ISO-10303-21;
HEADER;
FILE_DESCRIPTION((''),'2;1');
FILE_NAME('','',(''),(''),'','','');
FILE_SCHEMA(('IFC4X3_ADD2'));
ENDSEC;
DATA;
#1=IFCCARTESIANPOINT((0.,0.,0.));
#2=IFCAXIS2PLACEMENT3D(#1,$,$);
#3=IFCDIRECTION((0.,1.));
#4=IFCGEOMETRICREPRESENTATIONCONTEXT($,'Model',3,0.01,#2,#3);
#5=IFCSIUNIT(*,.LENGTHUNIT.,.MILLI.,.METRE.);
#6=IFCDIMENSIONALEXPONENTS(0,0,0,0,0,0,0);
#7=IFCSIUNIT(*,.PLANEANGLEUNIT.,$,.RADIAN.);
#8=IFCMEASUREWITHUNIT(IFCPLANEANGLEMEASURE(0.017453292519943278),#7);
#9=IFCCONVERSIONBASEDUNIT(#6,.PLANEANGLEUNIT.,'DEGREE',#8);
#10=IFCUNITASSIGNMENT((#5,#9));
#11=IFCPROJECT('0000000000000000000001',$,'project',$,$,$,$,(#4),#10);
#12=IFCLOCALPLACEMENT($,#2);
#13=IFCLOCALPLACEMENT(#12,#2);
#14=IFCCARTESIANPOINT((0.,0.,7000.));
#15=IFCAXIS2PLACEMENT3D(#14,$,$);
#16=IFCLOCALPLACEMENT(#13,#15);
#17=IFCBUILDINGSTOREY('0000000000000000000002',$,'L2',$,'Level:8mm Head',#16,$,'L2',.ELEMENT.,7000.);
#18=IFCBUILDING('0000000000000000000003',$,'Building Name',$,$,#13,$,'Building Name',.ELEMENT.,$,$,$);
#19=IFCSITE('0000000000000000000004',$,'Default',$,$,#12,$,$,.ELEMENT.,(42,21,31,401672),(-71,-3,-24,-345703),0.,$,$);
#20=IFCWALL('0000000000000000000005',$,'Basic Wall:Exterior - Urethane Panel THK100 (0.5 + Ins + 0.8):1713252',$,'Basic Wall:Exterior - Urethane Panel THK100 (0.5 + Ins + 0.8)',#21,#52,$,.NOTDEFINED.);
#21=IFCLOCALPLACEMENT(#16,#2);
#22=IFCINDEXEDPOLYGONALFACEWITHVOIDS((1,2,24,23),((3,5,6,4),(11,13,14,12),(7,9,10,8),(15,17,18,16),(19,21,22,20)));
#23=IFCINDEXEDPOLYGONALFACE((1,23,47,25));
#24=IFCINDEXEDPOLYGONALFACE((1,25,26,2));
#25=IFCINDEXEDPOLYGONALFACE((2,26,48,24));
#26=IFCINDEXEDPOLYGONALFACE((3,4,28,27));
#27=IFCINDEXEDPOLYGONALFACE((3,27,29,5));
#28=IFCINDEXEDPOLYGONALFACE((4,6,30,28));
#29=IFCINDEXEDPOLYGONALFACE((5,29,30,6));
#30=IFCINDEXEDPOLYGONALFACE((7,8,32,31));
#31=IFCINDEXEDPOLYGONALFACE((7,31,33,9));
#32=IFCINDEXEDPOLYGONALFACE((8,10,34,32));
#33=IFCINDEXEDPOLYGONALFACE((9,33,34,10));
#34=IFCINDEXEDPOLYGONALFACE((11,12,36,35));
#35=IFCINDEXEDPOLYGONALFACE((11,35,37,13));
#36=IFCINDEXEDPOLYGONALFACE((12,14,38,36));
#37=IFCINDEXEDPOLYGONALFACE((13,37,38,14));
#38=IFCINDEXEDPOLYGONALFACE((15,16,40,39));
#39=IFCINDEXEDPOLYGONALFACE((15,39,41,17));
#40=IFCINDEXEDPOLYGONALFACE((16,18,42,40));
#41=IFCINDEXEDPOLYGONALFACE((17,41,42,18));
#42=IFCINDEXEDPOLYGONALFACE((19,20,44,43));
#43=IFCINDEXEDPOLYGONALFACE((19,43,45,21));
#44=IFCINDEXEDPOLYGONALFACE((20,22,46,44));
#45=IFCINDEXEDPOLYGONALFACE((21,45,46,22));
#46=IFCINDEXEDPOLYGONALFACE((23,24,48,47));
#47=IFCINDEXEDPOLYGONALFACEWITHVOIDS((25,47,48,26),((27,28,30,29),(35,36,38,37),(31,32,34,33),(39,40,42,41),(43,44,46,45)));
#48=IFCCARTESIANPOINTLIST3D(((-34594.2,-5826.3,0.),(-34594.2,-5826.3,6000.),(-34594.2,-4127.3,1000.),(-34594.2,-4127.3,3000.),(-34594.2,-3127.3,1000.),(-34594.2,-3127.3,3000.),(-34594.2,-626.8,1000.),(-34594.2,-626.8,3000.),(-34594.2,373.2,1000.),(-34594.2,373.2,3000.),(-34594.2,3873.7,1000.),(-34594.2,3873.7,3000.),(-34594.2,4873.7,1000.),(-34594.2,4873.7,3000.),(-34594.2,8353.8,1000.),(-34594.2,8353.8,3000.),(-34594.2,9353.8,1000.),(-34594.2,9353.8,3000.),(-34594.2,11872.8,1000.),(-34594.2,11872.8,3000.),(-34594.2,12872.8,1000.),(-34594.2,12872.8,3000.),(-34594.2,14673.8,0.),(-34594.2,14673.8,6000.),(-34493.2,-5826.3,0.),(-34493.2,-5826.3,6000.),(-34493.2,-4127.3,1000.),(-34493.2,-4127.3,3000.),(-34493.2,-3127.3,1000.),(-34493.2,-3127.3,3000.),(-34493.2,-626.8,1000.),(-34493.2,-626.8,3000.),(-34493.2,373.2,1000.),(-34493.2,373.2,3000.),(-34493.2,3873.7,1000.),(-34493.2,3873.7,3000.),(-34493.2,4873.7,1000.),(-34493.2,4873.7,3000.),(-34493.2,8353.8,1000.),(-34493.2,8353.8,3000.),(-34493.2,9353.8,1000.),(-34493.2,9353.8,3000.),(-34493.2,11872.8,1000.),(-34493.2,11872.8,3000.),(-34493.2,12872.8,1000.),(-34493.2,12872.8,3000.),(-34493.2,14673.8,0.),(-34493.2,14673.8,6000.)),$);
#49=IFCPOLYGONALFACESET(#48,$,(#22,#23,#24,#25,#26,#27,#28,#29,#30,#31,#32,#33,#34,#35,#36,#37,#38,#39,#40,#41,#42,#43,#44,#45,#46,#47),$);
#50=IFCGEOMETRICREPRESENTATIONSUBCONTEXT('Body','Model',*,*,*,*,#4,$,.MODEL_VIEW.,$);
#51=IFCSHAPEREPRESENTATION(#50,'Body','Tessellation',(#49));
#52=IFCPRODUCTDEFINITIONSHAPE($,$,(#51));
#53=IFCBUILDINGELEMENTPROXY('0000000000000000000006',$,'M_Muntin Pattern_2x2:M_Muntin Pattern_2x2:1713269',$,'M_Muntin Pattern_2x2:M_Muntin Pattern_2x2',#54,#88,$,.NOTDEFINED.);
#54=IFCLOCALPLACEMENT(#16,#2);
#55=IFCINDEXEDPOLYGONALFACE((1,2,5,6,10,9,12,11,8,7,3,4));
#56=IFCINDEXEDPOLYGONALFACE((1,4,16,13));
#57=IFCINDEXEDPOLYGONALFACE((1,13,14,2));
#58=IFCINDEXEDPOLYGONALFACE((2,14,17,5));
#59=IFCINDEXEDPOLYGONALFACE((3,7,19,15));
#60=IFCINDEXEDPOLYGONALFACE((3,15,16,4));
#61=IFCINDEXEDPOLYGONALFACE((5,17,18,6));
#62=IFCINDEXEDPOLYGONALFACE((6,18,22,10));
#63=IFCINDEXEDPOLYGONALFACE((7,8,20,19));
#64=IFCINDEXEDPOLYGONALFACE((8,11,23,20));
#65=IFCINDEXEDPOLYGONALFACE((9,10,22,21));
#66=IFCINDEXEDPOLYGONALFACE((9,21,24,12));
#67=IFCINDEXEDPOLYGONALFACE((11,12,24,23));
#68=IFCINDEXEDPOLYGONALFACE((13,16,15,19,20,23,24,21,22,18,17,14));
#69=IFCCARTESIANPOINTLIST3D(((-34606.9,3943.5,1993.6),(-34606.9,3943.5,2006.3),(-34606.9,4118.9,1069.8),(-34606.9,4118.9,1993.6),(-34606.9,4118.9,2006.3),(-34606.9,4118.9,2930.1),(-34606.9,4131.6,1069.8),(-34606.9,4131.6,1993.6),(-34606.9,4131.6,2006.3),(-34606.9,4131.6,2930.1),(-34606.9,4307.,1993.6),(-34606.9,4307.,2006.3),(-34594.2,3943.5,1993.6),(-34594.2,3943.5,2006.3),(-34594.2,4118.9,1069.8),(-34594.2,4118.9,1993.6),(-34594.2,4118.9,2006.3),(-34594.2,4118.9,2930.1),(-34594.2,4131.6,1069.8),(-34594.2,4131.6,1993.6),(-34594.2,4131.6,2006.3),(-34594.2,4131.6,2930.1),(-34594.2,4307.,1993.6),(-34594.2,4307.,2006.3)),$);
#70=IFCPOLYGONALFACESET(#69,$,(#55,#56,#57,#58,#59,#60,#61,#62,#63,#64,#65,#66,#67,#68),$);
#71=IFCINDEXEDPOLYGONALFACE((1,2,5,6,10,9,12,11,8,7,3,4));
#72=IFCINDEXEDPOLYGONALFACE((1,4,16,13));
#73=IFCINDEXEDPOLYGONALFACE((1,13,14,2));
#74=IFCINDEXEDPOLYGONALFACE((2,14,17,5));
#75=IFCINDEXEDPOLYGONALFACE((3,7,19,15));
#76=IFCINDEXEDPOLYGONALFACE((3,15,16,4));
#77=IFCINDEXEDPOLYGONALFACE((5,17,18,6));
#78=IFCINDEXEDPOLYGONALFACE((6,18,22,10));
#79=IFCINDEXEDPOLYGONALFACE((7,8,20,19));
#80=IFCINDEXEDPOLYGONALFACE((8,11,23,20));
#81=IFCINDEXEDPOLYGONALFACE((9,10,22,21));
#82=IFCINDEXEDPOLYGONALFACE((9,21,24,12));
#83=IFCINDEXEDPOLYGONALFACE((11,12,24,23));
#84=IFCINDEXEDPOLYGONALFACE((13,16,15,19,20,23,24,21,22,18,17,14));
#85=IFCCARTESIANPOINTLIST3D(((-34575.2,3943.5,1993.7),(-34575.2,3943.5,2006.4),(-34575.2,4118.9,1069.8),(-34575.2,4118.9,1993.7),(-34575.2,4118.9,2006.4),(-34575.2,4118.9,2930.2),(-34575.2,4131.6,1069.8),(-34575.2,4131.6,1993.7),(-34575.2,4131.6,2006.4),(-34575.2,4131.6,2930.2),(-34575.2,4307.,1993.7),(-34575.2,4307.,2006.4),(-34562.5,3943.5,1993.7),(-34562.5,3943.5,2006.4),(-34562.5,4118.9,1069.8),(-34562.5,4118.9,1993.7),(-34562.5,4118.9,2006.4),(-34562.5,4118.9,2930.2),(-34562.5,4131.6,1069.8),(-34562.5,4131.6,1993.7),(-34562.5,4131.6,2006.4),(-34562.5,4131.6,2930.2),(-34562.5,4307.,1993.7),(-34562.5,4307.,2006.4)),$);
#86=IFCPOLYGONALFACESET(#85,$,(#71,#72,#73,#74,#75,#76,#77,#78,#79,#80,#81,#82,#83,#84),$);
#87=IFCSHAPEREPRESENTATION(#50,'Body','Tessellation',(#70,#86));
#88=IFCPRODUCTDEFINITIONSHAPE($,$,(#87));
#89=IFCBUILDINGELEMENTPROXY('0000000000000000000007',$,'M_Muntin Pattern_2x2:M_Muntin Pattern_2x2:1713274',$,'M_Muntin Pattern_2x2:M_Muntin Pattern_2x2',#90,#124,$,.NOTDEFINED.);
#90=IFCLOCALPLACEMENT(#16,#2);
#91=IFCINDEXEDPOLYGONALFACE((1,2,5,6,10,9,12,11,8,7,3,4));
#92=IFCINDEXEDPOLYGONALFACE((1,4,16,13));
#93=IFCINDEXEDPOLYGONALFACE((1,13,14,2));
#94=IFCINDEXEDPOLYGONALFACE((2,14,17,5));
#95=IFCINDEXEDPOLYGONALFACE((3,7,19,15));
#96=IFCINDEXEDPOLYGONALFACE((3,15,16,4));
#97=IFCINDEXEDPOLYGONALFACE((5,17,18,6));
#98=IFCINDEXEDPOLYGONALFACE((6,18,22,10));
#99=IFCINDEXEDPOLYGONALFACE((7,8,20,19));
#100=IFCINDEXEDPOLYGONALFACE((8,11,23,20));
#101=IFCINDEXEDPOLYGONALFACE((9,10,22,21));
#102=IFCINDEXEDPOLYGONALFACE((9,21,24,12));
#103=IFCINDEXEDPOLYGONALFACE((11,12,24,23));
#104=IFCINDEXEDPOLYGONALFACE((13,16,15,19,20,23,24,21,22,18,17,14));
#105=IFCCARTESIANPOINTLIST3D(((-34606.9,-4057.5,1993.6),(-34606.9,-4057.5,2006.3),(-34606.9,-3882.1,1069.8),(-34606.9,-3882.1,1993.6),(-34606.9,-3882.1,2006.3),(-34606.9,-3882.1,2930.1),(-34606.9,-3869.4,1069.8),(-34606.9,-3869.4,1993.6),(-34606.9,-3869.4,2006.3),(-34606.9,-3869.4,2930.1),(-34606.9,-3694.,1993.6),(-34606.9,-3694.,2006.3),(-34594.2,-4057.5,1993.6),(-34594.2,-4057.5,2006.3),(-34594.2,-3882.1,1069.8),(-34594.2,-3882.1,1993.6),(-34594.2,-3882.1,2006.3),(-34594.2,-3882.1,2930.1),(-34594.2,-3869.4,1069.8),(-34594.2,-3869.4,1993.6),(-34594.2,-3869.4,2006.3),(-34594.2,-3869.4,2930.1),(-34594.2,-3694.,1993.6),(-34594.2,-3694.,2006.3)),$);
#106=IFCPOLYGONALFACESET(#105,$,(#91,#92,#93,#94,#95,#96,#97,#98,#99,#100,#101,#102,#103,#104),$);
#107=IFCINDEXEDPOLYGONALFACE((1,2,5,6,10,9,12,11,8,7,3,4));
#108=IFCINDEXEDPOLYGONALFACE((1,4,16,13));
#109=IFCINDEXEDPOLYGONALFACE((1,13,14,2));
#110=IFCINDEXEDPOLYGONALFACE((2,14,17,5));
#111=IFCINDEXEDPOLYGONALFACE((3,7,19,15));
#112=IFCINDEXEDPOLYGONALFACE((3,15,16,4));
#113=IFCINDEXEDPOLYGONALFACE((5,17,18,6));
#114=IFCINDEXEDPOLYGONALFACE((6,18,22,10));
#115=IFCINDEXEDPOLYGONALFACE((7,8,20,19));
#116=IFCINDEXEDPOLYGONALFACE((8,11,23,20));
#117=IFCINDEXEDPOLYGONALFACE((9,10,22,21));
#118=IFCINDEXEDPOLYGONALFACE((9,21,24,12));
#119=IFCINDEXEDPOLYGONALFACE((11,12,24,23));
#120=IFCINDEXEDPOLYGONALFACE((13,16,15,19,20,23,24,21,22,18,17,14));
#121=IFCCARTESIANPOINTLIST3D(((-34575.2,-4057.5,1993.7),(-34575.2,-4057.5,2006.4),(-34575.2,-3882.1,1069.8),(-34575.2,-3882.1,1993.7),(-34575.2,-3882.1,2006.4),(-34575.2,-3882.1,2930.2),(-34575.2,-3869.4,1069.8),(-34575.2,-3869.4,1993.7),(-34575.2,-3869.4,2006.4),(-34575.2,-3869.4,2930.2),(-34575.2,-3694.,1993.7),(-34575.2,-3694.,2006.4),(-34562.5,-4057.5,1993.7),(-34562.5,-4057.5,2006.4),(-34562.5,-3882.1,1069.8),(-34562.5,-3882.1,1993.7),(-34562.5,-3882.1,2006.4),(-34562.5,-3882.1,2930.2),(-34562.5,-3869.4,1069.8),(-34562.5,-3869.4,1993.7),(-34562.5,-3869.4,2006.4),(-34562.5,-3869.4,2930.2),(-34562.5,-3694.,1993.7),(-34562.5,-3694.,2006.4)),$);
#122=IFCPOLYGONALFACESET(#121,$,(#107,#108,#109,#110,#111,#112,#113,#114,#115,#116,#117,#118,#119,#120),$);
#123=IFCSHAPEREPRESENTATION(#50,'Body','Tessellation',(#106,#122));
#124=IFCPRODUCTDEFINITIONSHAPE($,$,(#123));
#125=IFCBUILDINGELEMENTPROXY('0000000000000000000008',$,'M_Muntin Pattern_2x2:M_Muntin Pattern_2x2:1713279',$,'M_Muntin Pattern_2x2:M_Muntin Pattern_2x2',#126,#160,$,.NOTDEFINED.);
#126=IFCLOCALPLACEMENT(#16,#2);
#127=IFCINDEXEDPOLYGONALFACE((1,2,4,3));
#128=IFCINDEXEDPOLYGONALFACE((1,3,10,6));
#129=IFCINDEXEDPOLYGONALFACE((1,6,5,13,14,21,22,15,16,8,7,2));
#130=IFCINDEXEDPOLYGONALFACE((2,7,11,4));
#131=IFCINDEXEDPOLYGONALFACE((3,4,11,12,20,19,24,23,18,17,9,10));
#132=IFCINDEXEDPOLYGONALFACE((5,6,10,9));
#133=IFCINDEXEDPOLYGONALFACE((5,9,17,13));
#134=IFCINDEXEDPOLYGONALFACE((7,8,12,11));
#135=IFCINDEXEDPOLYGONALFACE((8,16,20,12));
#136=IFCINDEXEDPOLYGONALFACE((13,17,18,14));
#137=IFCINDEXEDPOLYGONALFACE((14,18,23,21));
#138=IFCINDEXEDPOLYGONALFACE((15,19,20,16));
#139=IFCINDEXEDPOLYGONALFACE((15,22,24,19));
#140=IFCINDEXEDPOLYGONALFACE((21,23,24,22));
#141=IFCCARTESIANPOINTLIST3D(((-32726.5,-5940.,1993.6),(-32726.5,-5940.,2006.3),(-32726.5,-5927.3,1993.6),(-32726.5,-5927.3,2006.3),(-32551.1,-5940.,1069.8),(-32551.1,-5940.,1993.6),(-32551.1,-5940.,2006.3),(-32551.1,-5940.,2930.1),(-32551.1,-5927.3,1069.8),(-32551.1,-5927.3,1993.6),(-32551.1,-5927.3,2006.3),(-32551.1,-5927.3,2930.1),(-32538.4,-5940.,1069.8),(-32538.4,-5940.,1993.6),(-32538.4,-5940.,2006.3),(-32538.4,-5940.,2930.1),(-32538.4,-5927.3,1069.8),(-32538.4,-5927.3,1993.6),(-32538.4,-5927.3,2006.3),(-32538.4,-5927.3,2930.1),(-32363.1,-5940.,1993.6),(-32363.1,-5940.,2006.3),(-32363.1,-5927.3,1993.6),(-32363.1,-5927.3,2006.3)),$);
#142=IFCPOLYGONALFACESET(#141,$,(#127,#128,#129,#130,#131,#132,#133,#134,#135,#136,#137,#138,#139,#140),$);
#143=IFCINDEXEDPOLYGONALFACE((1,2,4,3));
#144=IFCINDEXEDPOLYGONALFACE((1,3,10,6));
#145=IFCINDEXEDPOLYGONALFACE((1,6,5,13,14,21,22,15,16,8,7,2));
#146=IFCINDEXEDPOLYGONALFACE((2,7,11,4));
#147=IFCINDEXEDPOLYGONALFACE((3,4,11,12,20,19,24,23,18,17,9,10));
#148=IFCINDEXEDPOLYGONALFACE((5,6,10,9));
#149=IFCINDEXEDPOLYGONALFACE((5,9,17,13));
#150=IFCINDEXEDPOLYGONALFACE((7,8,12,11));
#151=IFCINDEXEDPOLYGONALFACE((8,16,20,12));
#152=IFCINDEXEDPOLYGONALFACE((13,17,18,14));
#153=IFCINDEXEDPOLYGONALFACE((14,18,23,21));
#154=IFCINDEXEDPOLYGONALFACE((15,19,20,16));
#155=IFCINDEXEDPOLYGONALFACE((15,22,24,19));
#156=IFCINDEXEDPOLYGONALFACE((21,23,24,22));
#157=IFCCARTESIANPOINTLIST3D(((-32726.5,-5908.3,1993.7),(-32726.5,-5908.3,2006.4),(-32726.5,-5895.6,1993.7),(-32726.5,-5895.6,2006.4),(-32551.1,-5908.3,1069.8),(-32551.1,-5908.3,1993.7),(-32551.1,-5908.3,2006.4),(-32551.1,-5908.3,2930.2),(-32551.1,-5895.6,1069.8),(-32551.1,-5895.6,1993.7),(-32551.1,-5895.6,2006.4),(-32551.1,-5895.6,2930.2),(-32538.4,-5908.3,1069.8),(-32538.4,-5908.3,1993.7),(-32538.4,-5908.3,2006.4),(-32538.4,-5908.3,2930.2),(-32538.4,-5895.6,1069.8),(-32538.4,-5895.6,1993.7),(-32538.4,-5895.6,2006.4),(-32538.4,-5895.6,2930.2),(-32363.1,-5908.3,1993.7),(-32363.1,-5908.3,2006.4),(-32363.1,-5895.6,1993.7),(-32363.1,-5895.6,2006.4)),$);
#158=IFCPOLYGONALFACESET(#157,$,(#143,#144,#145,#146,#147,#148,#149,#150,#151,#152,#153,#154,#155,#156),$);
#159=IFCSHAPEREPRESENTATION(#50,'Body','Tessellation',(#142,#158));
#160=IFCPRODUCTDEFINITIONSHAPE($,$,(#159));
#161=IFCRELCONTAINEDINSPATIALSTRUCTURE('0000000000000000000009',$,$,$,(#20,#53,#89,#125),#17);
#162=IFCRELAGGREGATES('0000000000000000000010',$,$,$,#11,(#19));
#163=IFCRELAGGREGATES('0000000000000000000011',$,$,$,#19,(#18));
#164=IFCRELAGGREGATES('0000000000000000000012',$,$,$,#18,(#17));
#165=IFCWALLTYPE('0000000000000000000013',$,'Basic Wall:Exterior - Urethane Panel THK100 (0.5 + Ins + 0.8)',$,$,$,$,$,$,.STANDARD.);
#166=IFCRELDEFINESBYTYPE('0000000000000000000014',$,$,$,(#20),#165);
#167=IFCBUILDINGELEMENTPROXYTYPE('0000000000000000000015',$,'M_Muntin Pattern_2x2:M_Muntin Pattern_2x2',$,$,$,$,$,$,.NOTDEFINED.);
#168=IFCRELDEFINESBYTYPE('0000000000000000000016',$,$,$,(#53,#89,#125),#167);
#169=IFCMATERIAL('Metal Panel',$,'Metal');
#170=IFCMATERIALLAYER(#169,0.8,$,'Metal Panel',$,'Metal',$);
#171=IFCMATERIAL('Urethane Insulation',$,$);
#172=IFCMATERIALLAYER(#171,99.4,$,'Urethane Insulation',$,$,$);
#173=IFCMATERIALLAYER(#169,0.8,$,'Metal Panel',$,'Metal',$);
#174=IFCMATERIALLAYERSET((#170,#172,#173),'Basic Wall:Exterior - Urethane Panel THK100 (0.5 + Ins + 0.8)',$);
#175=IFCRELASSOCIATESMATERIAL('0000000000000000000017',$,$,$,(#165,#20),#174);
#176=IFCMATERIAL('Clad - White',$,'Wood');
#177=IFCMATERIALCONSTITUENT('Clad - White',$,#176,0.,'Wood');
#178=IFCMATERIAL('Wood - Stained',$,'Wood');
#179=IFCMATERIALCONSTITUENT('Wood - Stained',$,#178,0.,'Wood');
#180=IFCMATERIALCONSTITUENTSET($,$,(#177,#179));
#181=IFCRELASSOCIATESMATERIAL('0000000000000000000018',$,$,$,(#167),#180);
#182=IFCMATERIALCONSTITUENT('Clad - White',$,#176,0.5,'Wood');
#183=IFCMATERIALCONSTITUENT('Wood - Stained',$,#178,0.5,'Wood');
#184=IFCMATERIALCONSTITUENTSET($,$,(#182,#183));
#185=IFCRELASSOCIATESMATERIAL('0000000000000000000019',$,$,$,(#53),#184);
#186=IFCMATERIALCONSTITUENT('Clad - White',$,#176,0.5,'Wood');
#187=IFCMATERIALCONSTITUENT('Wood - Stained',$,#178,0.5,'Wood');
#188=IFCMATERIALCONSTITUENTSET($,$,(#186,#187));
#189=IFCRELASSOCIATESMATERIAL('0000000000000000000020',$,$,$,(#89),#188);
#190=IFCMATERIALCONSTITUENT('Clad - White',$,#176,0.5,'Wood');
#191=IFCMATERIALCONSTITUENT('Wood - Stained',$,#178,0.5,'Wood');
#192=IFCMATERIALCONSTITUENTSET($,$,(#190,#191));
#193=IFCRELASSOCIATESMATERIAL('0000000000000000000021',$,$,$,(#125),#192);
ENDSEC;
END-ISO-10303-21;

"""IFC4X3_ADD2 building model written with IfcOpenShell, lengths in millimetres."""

from ifc_helpers import new_model, entity, si_unit, converted_unit, direction, frame, frame_2d, origin, place, context, subcontext, project, spatial, polyline, rectangle, outline, extrude, source, transform, mapped, material, layer, layer_set, constituent, constituent_set, type_object, type_shapes, element, save


model = new_model("IFC4X3_ADD2")

# Units and contexts
model_context = context("Model", 3, precision=0.01, world=origin(), true_north=direction((0.0, 1.0)))
body_context = subcontext(model_context, "Body", "Model", "MODEL_VIEW")
ifc_project = project(units=[si_unit("LENGTHUNIT", "METRE", prefix="MILLI"), converted_unit("PLANEANGLEUNIT", "DEGREE", entity("IfcPlaneAngleMeasure", 0.017453292519943278), si_unit("PLANEANGLEUNIT", "RADIAN"), dimensions=[0, 0, 0, 0, 0, 0, 0])], contexts=[model_context])

# Site, building, storey
site_placement = place(None, origin())
site = spatial("IfcSite", under=ifc_project, at=site_placement, Name="Default", CompositionType="ELEMENT", RefLatitude=(42, 21, 31, 401672), RefLongitude=(-71, -3, -24, -345703), RefElevation=0.0)
building_placement = place(site_placement, origin())
building = spatial("IfcBuilding", under=site, at=building_placement, Name="Building Name", LongName="Building Name", CompositionType="ELEMENT")
storey_placement = place(building_placement, frame((0.0, 0.0, 7000.0)))
storey = spatial("IfcBuildingStorey", under=building, at=storey_placement, Name="L2", ObjectType="Level:8mm Head", LongName="L2", CompositionType="ELEMENT", Elevation=7000.0)

# Wall, openings
ifc_material_1 = material(Name="Metal Panel", Category="Metal")
ifc_layer_1 = layer(ifc_material_1, 0.8, Name="Metal Panel", Category="Metal")
ifc_material_2 = material(Name="Urethane Insulation")
ifc_layer_2 = layer(ifc_material_2, 99.4, Name="Urethane Insulation")
ifc_layer_3 = layer(ifc_material_1, 0.8, Name="Metal Panel", Category="Metal")
ifc_layer_set = layer_set([ifc_layer_1, ifc_layer_2, ifc_layer_3], Name="Basic Wall:Exterior - Urethane Panel THK100 (0.5 + Ins + 0.8)")
wall_type = type_object("IfcWallType", Name="Basic Wall:Exterior - Urethane Panel THK100 (0.5 + Ins + 0.8)", PredefinedType="STANDARD", material=ifc_layer_set)
wall_placement = place(storey_placement, frame((-34543.7, -5826.3, 0.0), z_axis=(0.0, 0.0, 1.0), x_axis=(0.0, 1.0, 0.0)))
wall = element("IfcWall", 1, at=wall_placement, inside=storey, type_object=wall_type, material=ifc_layer_set, Name="Basic Wall:Exterior - Urethane Panel THK100 (0.5 + Ins + 0.8):1713252", ObjectType="Basic Wall:Exterior - Urethane Panel THK100 (0.5 + Ins + 0.8)", PredefinedType="NOTDEFINED", context=body_context, shape_type="SweptSolid", body=[
    extrude(rectangle(XDim=20500.1, YDim=101.0, at=frame_2d((10250.0, 0.0), x_axis=(-1.0, 0.0))), origin(), (0.0, 0.0, 1.0), 6000.0),
])
opening_1_placement = place(wall_placement, frame((17699.1, -50.5, 1000.0)))
element("IfcOpeningElement", 2, at=opening_1_placement, cuts=wall, PredefinedType="OPENING", context=body_context, shape_type="SweptSolid", body=[
    extrude(rectangle(XDim=2000.0, YDim=1000.0, at=frame_2d((1000.0, 500.0), x_axis=(-1.0, 0.0))), frame((0.0, 0.0, 0.0), z_axis=(0.0, 1.0, 0.0), x_axis=(0.0, 0.0, 1.0)), (0.0, 0.0, 1.0), 101.0),
])
opening_2_placement = place(wall_placement, frame((14180.1, -50.5, 1000.0)))
element("IfcOpeningElement", 3, at=opening_2_placement, cuts=wall, PredefinedType="OPENING", context=body_context, shape_type="SweptSolid", body=[
    extrude(rectangle(XDim=2000.0, YDim=1000.0, at=frame_2d((1000.0, 500.0), x_axis=(-1.0, 0.0))), frame((0.0, 0.0, 0.0), z_axis=(0.0, 1.0, 0.0), x_axis=(0.0, 0.0, 1.0)), (0.0, 0.0, 1.0), 101.0),
])
opening_3_placement = place(wall_placement, frame((9700.0, -50.5, 1000.0)))
element("IfcOpeningElement", 4, at=opening_3_placement, cuts=wall, PredefinedType="OPENING", context=body_context, shape_type="SweptSolid", body=[
    extrude(rectangle(XDim=2000.0, YDim=1000.0, at=frame_2d((1000.0, 500.0), x_axis=(-1.0, 0.0))), frame((0.0, 0.0, 0.0), z_axis=(0.0, 1.0, 0.0), x_axis=(0.0, 0.0, 1.0)), (0.0, 0.0, 1.0), 101.0),
])
opening_4_placement = place(wall_placement, frame((1699.0, -50.5, 1000.0)))
element("IfcOpeningElement", 5, at=opening_4_placement, cuts=wall, PredefinedType="OPENING", context=body_context, shape_type="SweptSolid", body=[
    extrude(rectangle(XDim=2000.0, YDim=1000.0, at=frame_2d((1000.0, 500.0), x_axis=(-1.0, 0.0))), frame((0.0, 0.0, 0.0), z_axis=(0.0, 1.0, 0.0), x_axis=(0.0, 0.0, 1.0)), (0.0, 0.0, 1.0), 101.0),
])
opening_5_placement = place(wall_placement, frame((5199.5, -50.5, 1000.0)))
element("IfcOpeningElement", 6, at=opening_5_placement, cuts=wall, PredefinedType="OPENING", context=body_context, shape_type="SweptSolid", body=[
    extrude(rectangle(XDim=2000.0, YDim=1000.0, at=frame_2d((1000.0, 500.0), x_axis=(-1.0, 0.0))), frame((0.0, 0.0, 0.0), z_axis=(0.0, 1.0, 0.0), x_axis=(0.0, 0.0, 1.0)), (0.0, 0.0, 1.0), 101.0),
])

# Building element proxies
ifc_material_3 = material(Name="Clad - White", Category="Wood")
ifc_constituent_1 = constituent(ifc_material_3, Name="Clad - White", Category="Wood", fraction=0.5)
ifc_material_4 = material(Name="Wood - Stained", Category="Wood")
ifc_constituent_2 = constituent(ifc_material_4, Name="Wood - Stained", Category="Wood", fraction=0.5)
ifc_constituent_set_1 = constituent_set(constituents=[ifc_constituent_1, ifc_constituent_2])
ifc_constituent_3 = constituent(ifc_material_3, Name="Clad - White", Category="Wood", fraction=0.0)
ifc_constituent_4 = constituent(ifc_material_4, Name="Wood - Stained", Category="Wood", fraction=0.0)
ifc_constituent_set_2 = constituent_set(constituents=[ifc_constituent_3, ifc_constituent_4])
building_element_proxy_type_1 = type_object("IfcBuildingElementProxyType", Name="M_Muntin Pattern_2x2:M_Muntin Pattern_2x2", PredefinedType="NOTDEFINED", material=ifc_constituent_set_2)
shared_shape_1 = source(origin(), body_context, "Body", "SweptSolid", [
    extrude(outline(polyline([(6.4, -6.4), (930.1, -6.4), (930.1, 6.3), (6.4, 6.3), (6.4, 181.7), (-6.3, 181.7), (-6.3, 6.3), (-930.2, 6.3), (-930.2, -6.4), (-6.3, -6.4), (-6.3, -181.7), (6.4, -181.7), (6.4, -6.4)])), frame((0.0, 9.5, 930.1), z_axis=(0.0, 1.0, 0.0), x_axis=(0.0, 0.0, 1.0)), (0.0, 0.0, 1.0), 12.7),
    extrude(outline(polyline([(6.4, -6.4), (930.2, -6.4), (930.2, 6.3), (6.4, 6.3), (6.4, 181.7), (-6.3, 181.7), (-6.3, 6.3), (-930.2, 6.3), (-930.2, -6.4), (-6.3, -6.4), (-6.3, -181.7), (6.4, -181.7), (6.4, -6.4)])), frame((0.0, -22.2, 930.2), z_axis=(0.0, 1.0, 0.0), x_axis=(0.0, 0.0, 1.0)), (0.0, 0.0, 1.0), 12.7),
])
type_shapes(building_element_proxy_type_1, [shared_shape_1])
proxy_1_placement = place(storey_placement, frame((-34584.7, 4125.3, 1069.8), z_axis=(0.0, 0.0, 1.0), x_axis=(0.0, 1.0, 0.0)))
element("IfcBuildingElementProxy", 7, at=proxy_1_placement, inside=storey, type_object=building_element_proxy_type_1, material=ifc_constituent_set_1, Name="M_Muntin Pattern_2x2:M_Muntin Pattern_2x2:1713269", ObjectType="M_Muntin Pattern_2x2:M_Muntin Pattern_2x2", PredefinedType="NOTDEFINED", context=body_context, shape_type="MappedRepresentation", body=[
    mapped(shared_shape_1, transform((0.0, 0.0, 0.0), scale=1.0)),
])
ifc_constituent_5 = constituent(ifc_material_3, Name="Clad - White", Category="Wood", fraction=0.5)
ifc_constituent_6 = constituent(ifc_material_4, Name="Wood - Stained", Category="Wood", fraction=0.5)
ifc_constituent_set_3 = constituent_set(constituents=[ifc_constituent_5, ifc_constituent_6])
proxy_2_placement = place(storey_placement, frame((-34584.7, -3875.7, 1069.8), z_axis=(0.0, 0.0, 1.0), x_axis=(0.0, 1.0, 0.0)))
element("IfcBuildingElementProxy", 8, at=proxy_2_placement, inside=storey, type_object=building_element_proxy_type_1, material=ifc_constituent_set_3, Name="M_Muntin Pattern_2x2:M_Muntin Pattern_2x2:1713274", ObjectType="M_Muntin Pattern_2x2:M_Muntin Pattern_2x2", PredefinedType="NOTDEFINED", context=body_context, shape_type="MappedRepresentation", body=[
    mapped(shared_shape_1, transform((0.0, 0.0, 0.0), scale=1.0)),
])
ifc_constituent_7 = constituent(ifc_material_3, Name="Clad - White", Category="Wood", fraction=0.5)
ifc_constituent_8 = constituent(ifc_material_4, Name="Wood - Stained", Category="Wood", fraction=0.5)
ifc_constituent_set_4 = constituent_set(constituents=[ifc_constituent_7, ifc_constituent_8])
proxy_3_placement = place(storey_placement, frame((-32544.8, -5917.8, 1069.8), z_axis=(0.0, 0.0, 1.0), x_axis=(-1.0, 0.0, 0.0)))
element("IfcBuildingElementProxy", 9, at=proxy_3_placement, inside=storey, type_object=building_element_proxy_type_1, material=ifc_constituent_set_4, Name="M_Muntin Pattern_2x2:M_Muntin Pattern_2x2:1713279", ObjectType="M_Muntin Pattern_2x2:M_Muntin Pattern_2x2", PredefinedType="NOTDEFINED", context=body_context, shape_type="MappedRepresentation", body=[
    mapped(shared_shape_1, transform((0.0, 0.0, 0.0), scale=1.0)),
])

save(model, "model.ifc")
